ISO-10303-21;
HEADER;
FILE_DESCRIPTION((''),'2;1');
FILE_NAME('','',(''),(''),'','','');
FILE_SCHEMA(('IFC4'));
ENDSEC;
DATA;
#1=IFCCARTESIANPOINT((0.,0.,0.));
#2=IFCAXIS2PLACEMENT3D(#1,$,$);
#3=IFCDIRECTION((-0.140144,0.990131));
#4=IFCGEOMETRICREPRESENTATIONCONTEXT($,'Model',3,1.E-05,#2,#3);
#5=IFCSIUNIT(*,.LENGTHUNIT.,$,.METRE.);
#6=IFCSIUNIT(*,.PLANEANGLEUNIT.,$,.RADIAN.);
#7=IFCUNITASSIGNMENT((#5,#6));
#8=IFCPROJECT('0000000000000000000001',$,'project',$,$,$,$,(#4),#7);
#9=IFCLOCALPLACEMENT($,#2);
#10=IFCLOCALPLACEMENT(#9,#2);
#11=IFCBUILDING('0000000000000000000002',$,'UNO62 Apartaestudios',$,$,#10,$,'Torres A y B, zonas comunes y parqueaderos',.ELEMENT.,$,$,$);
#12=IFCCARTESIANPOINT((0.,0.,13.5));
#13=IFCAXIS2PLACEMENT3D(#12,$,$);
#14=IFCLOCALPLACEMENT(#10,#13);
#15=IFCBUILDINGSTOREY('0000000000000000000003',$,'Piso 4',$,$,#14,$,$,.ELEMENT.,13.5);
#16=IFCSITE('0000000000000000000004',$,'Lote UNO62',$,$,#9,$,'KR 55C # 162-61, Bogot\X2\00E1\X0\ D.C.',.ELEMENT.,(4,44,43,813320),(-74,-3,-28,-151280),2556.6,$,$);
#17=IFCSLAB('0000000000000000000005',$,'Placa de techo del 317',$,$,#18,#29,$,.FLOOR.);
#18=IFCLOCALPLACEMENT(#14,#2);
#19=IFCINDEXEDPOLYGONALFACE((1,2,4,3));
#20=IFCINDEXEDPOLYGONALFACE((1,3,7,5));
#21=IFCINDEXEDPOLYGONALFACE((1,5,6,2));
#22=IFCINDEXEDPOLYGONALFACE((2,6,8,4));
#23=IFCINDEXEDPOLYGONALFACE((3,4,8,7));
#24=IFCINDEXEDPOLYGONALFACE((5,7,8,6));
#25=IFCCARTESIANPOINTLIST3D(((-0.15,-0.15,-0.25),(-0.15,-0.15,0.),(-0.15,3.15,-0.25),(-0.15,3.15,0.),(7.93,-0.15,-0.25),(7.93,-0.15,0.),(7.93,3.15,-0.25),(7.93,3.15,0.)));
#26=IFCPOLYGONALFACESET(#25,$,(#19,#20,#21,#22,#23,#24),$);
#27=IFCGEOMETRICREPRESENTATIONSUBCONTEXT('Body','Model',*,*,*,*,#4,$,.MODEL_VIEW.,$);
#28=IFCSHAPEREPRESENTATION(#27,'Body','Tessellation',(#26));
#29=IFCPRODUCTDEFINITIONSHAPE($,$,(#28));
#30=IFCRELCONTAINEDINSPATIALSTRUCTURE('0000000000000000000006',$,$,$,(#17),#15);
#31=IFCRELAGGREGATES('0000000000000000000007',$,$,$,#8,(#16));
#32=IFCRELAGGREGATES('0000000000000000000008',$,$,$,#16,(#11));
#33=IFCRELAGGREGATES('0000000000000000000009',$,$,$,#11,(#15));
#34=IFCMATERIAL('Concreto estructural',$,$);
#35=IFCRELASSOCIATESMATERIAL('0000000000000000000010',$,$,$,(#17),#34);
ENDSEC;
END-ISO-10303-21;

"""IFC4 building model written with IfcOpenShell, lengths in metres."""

from ifc_helpers import new_model, si_unit, direction, frame, frame_2d, origin, place, context, subcontext, project, spatial, rectangle, extrude, material, element, save


model = new_model("IFC4")

# Units and contexts
model_context = context("Model", 3, precision=1e-05, world=origin(), true_north=direction((-0.140144, 0.990131)))
body_context = subcontext(model_context, "Body", "Model", "MODEL_VIEW")
ifc_project = project(units=[si_unit("LENGTHUNIT", "METRE"), si_unit("PLANEANGLEUNIT", "RADIAN")], contexts=[model_context])

# Site, building, storey
site_placement = place(None, origin())
site = spatial("IfcSite", under=ifc_project, at=site_placement, Name="Lote UNO62", LongName="KR 55C # 162-61, Bogotá D.C.", CompositionType="ELEMENT", RefLatitude=(4, 44, 43, 813320), RefLongitude=(-74, -3, -28, -151280), RefElevation=2556.6)
building_placement = place(site_placement, origin())
building = spatial("IfcBuilding", under=site, at=building_placement, Name="UNO62 Apartaestudios", LongName="Torres A y B, zonas comunes y parqueaderos", CompositionType="ELEMENT")
storey_placement = place(building_placement, frame((0.0, 0.0, 13.5)))
storey = spatial("IfcBuildingStorey", under=building, at=storey_placement, Name="Piso 4", CompositionType="ELEMENT", Elevation=13.5)

# Slab
ifc_material = material(Name="Concreto estructural")
slab_placement = place(storey_placement, origin())
element("IfcSlab", 1, at=slab_placement, inside=storey, material=ifc_material, Name="Placa de techo del 317", PredefinedType="FLOOR", context=body_context, shape_type="SweptSolid", body=[
    extrude(rectangle(XDim=8.08, YDim=3.3, at=frame_2d((3.89, 1.5))), frame((0.0, 0.0, -0.25)), (0.0, 0.0, 1.0), 0.25),
])

save(model, "model.ifc")
